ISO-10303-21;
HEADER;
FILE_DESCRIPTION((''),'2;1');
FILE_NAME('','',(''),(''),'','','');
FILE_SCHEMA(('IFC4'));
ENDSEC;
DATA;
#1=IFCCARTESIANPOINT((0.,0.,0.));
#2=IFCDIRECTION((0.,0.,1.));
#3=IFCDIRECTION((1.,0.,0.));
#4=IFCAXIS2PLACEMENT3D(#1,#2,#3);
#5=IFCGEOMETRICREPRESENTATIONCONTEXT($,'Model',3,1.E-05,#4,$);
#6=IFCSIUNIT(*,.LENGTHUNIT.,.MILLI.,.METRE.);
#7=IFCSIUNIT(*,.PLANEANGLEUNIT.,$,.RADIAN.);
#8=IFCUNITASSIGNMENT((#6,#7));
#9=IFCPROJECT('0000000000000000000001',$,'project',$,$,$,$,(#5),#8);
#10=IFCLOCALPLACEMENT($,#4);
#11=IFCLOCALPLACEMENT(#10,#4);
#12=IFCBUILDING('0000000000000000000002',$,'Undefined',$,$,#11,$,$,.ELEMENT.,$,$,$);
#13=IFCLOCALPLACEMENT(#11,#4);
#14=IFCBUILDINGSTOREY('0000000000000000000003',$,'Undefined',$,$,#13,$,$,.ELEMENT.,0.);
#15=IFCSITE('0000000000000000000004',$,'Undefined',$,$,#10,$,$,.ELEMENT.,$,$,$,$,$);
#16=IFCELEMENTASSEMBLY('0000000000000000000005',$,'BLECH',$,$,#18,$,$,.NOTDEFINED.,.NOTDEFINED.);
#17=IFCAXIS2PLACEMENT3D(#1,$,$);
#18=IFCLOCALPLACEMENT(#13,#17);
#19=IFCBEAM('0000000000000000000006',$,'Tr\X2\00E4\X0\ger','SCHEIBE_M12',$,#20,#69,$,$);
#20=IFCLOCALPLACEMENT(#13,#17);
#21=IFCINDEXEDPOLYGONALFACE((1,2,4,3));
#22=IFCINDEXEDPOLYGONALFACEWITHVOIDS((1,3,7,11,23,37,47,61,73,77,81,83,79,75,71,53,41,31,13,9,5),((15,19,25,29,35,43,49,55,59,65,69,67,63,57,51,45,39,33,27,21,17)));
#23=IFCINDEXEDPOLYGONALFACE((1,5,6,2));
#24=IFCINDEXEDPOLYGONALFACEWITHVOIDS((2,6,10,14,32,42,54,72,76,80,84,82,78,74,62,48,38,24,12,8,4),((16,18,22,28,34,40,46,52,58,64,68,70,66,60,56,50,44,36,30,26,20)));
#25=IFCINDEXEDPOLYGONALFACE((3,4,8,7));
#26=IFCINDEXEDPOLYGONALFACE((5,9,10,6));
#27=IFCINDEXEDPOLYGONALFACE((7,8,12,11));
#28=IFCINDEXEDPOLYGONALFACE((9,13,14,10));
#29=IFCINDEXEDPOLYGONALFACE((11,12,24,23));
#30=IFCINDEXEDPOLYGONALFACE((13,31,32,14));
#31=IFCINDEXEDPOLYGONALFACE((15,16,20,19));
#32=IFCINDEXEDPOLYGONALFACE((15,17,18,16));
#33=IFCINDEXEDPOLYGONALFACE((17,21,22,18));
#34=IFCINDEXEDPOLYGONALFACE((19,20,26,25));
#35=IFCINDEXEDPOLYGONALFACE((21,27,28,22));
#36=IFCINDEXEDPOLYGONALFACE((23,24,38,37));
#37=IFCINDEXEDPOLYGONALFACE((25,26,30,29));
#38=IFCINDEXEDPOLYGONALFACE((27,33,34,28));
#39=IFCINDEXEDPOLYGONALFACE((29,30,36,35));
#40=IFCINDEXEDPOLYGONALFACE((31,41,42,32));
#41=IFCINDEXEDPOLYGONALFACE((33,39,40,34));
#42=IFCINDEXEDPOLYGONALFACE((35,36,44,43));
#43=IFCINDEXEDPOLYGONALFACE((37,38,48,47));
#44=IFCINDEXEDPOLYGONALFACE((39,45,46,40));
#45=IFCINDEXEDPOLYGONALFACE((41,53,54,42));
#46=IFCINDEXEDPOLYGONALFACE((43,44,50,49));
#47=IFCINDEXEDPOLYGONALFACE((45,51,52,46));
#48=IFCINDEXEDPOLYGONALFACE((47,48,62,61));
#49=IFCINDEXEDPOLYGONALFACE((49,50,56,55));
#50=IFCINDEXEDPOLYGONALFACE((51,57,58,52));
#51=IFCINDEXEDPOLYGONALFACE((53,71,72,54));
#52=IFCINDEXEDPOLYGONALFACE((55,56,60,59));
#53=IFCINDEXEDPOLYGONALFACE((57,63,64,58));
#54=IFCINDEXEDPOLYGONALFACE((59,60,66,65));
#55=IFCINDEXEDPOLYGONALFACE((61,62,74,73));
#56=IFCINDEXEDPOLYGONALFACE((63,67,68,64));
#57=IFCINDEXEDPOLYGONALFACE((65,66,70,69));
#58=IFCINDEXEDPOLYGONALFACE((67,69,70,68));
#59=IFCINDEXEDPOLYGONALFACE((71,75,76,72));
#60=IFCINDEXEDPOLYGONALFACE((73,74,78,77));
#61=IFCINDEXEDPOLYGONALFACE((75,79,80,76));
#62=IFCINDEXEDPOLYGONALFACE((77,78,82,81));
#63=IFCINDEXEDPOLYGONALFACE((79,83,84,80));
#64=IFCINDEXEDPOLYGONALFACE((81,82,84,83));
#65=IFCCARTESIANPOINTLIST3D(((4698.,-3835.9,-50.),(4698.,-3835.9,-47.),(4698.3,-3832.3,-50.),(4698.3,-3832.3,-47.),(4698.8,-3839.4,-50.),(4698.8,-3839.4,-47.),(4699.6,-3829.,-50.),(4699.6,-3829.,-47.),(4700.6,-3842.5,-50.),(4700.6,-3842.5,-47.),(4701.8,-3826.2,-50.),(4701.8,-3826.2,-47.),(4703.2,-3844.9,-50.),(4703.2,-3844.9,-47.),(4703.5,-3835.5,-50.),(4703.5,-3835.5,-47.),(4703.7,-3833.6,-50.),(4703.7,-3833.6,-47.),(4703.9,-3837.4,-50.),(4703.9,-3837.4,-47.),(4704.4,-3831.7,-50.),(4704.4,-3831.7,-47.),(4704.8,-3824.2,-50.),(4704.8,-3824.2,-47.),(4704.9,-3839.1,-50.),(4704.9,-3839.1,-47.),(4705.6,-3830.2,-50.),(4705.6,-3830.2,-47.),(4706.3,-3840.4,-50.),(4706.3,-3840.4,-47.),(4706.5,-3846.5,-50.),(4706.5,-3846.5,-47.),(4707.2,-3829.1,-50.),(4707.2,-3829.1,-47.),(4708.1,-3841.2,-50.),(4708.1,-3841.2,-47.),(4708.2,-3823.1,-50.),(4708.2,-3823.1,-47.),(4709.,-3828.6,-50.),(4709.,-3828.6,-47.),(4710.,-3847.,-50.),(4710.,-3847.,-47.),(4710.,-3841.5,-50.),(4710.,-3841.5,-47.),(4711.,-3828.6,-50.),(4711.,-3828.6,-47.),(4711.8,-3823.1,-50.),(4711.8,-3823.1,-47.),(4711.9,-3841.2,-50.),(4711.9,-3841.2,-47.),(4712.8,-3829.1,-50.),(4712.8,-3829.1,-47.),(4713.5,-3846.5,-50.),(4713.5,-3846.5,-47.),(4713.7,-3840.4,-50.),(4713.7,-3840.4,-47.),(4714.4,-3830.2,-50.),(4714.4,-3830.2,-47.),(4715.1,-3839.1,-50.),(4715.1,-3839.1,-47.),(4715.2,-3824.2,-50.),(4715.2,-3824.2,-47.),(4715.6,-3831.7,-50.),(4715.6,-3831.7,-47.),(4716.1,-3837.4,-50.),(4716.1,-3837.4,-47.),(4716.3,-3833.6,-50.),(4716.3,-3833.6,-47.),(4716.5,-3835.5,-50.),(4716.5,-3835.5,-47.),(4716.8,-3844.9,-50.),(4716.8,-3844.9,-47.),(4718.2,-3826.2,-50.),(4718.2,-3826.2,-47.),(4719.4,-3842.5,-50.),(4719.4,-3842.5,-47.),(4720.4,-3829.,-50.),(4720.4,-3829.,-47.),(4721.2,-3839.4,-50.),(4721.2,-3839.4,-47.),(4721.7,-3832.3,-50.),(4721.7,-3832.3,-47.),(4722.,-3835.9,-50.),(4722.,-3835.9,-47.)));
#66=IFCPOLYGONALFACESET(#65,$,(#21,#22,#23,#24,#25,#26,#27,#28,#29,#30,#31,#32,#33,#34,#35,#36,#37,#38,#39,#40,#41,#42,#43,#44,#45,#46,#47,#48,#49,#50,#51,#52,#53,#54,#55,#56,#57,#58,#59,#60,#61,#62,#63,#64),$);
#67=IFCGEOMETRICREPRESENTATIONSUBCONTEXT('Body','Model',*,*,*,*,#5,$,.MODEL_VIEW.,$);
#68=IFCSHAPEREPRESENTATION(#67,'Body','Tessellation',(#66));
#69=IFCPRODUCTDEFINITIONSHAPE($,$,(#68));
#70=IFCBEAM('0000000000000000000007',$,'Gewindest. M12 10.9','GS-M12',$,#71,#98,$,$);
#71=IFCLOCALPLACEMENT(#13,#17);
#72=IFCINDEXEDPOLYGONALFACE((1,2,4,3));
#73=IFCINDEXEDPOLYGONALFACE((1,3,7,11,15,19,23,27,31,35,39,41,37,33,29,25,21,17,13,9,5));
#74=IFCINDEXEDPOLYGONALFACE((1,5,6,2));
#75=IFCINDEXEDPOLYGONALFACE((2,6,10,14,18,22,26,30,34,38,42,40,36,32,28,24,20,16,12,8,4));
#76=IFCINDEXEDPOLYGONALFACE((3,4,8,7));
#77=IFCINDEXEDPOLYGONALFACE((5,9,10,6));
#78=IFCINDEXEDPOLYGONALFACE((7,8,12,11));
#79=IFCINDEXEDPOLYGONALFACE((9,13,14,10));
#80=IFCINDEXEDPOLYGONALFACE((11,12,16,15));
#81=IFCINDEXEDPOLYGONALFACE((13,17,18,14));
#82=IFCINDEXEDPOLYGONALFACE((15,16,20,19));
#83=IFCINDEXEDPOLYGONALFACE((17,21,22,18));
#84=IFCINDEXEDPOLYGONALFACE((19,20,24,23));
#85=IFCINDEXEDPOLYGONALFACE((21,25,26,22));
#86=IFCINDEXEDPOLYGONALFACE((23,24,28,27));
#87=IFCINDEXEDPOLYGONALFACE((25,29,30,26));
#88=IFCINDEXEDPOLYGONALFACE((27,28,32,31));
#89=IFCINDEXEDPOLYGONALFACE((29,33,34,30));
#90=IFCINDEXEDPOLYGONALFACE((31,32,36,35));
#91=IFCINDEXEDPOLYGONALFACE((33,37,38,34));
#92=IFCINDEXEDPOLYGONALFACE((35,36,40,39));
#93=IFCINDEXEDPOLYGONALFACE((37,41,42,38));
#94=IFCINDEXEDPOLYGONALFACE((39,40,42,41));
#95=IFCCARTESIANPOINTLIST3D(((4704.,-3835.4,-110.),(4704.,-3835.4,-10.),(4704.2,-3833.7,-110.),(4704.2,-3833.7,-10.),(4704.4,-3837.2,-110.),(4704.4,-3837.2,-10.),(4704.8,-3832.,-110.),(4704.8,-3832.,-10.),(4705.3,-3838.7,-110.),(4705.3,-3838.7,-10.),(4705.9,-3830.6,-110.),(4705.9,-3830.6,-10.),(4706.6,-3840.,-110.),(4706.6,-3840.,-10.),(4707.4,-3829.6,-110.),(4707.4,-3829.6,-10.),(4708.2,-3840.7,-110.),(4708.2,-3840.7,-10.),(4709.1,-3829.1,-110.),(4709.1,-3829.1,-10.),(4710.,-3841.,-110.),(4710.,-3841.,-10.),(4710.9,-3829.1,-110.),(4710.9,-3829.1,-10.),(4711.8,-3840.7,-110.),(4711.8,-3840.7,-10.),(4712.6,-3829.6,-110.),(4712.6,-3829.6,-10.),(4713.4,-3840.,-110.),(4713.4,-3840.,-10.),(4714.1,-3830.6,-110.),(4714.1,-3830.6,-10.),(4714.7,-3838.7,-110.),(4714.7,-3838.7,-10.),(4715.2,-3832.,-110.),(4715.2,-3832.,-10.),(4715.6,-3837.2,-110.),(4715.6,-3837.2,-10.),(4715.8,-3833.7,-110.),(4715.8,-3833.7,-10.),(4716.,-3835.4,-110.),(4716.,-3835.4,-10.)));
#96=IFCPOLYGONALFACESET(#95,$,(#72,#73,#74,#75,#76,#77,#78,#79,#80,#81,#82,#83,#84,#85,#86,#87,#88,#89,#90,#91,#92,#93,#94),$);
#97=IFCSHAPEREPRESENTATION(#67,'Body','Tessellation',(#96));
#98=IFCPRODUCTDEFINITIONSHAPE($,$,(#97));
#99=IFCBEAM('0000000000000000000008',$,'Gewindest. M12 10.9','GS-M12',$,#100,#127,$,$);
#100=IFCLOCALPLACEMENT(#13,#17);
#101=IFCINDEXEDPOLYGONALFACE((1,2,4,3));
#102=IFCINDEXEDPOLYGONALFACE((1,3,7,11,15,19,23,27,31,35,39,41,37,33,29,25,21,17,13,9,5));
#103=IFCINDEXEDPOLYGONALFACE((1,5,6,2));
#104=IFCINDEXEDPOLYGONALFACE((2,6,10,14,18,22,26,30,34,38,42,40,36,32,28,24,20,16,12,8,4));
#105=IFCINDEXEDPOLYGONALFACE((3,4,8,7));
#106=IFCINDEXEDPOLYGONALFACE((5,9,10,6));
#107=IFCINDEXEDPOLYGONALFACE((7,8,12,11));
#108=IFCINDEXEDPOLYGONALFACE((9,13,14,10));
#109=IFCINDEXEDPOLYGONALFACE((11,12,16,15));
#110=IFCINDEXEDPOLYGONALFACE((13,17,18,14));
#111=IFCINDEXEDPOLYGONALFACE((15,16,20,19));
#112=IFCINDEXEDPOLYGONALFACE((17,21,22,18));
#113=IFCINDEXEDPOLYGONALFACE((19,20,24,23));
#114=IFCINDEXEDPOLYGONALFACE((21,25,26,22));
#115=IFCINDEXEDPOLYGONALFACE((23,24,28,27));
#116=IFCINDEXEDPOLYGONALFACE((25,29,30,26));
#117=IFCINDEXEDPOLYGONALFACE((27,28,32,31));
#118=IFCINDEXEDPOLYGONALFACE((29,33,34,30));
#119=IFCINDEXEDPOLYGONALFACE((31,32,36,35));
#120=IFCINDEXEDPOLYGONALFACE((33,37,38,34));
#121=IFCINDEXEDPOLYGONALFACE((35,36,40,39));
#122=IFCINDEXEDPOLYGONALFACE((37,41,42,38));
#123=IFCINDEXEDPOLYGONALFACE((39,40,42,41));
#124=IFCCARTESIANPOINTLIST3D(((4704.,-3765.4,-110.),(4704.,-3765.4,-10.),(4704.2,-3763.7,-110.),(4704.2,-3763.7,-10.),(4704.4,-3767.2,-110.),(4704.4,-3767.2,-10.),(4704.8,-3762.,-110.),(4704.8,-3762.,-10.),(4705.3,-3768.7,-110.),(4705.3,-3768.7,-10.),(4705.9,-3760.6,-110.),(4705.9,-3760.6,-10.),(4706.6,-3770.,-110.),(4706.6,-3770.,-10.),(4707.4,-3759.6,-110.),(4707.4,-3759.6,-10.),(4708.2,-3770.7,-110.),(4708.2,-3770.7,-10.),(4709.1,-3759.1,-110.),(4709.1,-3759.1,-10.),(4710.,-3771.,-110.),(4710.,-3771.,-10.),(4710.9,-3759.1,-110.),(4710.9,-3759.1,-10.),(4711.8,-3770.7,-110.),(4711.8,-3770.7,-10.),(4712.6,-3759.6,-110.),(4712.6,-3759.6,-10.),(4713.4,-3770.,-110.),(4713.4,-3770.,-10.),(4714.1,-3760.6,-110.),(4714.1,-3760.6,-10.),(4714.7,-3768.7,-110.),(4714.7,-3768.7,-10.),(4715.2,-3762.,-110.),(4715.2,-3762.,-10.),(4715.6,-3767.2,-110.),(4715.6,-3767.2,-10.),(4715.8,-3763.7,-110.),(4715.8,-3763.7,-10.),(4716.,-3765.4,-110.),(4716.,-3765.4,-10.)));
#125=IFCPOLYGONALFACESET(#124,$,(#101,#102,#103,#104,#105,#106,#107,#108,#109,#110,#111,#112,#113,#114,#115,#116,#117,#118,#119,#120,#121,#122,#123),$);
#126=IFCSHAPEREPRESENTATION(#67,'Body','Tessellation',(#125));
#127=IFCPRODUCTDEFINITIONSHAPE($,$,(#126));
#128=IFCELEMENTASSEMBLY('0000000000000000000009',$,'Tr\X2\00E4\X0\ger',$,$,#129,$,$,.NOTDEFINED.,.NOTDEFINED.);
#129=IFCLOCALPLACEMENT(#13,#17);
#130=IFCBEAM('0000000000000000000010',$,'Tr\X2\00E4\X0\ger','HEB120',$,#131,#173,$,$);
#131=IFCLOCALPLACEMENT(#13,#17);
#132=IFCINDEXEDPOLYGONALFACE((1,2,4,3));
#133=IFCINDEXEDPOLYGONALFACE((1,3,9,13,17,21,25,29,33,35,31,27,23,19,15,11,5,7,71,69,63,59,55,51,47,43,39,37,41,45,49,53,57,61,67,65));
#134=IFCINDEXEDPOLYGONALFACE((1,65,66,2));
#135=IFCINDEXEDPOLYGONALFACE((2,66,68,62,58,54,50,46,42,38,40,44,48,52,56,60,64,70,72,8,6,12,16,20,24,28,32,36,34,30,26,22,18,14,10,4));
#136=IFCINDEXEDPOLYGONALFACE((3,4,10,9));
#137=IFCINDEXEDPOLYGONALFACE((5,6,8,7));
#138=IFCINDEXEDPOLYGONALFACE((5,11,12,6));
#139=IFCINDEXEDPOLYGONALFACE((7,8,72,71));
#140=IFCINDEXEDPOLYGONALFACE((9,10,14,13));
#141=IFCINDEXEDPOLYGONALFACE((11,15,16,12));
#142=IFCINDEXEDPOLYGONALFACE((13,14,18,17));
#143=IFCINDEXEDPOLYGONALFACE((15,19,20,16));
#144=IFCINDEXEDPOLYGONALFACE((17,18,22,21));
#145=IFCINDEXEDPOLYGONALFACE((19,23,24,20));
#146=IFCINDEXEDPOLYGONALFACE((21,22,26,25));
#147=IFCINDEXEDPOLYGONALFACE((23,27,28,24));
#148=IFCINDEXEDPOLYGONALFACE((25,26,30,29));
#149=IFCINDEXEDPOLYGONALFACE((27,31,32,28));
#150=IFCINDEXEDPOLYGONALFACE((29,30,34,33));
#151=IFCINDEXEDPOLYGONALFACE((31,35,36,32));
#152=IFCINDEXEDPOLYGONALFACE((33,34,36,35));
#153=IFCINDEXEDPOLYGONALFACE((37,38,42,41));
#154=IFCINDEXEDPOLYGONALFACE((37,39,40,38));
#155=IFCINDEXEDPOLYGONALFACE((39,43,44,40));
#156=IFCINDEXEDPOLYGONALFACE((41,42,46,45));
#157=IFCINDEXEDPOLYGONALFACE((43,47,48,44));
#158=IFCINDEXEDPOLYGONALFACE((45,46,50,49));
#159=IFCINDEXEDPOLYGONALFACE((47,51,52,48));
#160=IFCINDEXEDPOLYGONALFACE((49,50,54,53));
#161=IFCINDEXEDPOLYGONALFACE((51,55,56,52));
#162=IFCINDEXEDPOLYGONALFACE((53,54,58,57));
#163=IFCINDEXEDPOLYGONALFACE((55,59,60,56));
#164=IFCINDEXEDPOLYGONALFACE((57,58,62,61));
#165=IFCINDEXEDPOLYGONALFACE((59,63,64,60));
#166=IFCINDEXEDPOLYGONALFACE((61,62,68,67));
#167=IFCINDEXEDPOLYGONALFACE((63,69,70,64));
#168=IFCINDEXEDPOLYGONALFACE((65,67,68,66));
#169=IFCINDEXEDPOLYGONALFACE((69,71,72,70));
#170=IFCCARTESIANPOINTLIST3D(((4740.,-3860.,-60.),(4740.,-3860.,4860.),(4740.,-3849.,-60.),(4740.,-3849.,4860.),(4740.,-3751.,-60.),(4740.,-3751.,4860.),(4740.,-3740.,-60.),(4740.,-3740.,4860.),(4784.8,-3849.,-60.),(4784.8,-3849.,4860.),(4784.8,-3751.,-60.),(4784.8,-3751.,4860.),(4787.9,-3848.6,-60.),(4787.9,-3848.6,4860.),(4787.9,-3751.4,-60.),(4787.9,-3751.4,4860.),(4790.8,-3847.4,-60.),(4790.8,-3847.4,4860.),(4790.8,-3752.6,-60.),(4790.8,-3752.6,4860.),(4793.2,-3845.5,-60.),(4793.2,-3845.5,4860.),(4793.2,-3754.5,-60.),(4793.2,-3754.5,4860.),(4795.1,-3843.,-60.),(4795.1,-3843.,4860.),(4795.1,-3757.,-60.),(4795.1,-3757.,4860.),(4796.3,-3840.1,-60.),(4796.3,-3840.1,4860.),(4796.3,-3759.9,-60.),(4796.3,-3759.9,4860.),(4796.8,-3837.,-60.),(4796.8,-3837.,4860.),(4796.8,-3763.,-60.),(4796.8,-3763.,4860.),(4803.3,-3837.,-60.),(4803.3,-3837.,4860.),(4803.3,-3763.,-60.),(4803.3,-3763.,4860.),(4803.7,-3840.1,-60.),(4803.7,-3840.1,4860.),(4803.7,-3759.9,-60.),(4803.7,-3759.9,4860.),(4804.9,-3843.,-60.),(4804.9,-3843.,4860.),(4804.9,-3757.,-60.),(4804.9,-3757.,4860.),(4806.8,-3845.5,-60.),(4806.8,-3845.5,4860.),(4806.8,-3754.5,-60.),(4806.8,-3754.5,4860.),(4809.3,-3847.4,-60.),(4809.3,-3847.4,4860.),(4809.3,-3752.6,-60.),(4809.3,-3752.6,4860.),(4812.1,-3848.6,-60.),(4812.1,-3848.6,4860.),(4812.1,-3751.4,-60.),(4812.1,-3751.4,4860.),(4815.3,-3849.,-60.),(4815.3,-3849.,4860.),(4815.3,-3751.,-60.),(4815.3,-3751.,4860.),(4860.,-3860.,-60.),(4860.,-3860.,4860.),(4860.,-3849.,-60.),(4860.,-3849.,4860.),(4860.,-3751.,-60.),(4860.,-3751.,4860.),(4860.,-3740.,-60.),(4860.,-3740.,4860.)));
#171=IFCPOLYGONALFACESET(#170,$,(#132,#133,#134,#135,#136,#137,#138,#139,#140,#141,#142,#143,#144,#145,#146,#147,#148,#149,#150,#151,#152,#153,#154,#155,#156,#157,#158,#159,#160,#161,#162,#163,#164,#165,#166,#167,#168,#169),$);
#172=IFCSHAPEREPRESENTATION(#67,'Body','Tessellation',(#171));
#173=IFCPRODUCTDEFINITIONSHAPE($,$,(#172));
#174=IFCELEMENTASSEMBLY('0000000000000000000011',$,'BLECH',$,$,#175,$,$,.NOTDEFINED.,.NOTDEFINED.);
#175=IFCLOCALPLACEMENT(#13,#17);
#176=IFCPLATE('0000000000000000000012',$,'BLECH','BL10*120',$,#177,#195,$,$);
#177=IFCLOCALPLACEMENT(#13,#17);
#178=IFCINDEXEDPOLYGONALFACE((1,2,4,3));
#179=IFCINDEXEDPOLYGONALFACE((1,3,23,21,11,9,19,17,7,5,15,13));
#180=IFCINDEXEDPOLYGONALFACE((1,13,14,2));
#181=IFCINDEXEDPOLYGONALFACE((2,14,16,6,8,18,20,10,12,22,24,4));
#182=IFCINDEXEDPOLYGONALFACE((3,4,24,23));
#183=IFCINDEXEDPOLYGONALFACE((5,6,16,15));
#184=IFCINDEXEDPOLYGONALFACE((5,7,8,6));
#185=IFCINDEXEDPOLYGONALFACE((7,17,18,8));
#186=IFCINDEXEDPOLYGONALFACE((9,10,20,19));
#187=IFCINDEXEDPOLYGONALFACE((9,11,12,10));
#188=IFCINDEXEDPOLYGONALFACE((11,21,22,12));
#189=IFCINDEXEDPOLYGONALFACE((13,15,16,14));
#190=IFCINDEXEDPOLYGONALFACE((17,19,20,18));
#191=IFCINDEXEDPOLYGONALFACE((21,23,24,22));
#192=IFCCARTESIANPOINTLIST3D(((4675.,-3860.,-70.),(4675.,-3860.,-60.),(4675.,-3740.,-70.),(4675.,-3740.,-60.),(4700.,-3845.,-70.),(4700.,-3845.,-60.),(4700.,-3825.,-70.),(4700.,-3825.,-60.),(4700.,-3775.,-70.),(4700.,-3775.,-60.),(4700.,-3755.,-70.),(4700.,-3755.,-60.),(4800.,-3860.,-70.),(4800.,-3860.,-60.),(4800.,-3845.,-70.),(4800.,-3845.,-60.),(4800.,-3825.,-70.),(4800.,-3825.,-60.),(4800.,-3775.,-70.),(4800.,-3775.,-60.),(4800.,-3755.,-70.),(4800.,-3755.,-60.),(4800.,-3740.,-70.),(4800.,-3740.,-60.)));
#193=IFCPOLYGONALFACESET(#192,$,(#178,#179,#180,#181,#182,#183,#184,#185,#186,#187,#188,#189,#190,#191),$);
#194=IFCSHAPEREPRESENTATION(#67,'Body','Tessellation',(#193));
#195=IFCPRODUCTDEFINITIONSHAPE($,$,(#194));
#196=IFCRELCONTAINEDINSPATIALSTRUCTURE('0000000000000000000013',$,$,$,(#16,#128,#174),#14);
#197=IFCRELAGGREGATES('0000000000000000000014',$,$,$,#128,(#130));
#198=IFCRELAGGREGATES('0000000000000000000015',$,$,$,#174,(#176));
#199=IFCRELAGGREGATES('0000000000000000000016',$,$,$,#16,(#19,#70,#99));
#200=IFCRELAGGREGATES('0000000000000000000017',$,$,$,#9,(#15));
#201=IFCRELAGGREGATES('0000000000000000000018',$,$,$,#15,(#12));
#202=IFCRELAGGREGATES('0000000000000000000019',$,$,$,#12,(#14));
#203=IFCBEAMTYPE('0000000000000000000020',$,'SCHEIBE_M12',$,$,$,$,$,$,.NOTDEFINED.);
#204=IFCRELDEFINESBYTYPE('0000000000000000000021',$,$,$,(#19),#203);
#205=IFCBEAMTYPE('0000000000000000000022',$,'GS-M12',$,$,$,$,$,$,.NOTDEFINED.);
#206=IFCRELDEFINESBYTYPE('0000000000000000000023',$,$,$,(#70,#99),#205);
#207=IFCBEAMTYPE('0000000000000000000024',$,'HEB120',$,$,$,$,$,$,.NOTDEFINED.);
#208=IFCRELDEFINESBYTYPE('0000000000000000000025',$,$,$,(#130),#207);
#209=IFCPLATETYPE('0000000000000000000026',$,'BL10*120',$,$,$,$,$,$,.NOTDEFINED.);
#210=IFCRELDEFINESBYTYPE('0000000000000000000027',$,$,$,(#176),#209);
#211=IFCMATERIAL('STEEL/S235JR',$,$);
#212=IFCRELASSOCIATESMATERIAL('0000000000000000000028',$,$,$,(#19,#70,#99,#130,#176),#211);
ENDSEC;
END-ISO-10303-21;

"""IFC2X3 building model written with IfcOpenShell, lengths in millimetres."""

from ifc_helpers import new_model, si_unit, frame, origin_with_axes, origin_2d_with_axis, place, context, subcontext, project, spatial, polyline, circle, hollow_circle, i_section, outline, extrude, material, type_object, element, aggregate, save


model = new_model("IFC2X3")

# Units and contexts
model_context = context("Model", 3, precision=1e-05, world=origin_with_axes())
body_context = subcontext(model_context, "Body", "Model", "MODEL_VIEW")
ifc_project = project(units=[si_unit("LENGTHUNIT", "METRE", prefix="MILLI"), si_unit("PLANEANGLEUNIT", "RADIAN")], contexts=[model_context])

# Site, building, storey
site_placement = place(None, origin_with_axes())
site = spatial("IfcSite", under=ifc_project, at=site_placement, Name="Undefined", CompositionType="ELEMENT")
building_placement = place(site_placement, origin_with_axes())
building = spatial("IfcBuilding", under=site, at=building_placement, Name="Undefined", CompositionType="ELEMENT")
storey_placement = place(building_placement, origin_with_axes())
storey = spatial("IfcBuildingStorey", under=building, at=storey_placement, Name="Undefined", CompositionType="ELEMENT", Elevation=0.0)

# Shared definitions
ifc_material_1 = material(Name="STEEL/S235JR")

# Element assembly, beams
assembly_1_placement = place(storey_placement, origin_with_axes())
assembly_1 = element("IfcElementAssembly", 1, at=assembly_1_placement, inside=storey, Name="BLECH", AssemblyPlace="NOTDEFINED", PredefinedType="NOTDEFINED")
beam_type_1 = type_object("IfcBeamType", Name="SCHEIBE_M12", PredefinedType="NOTDEFINED")
beam_1_placement = place(assembly_1_placement, frame((4710.0, -3835.0, -47.0), z_axis=(1.0, 0.0, 0.0), x_axis=(0.0, 0.0, -1.0)))
beam_1 = element("IfcBeam", 2, at=beam_1_placement, type_object=beam_type_1, material=ifc_material_1, Name="Träger", Description="SCHEIBE_M12", context=body_context, shape_type="SweptSolid", body=[
    extrude(hollow_circle(Radius=12.0, WallThickness=5.5, at=origin_2d_with_axis()), frame((3.0, 0.0, 0.0), z_axis=(-1.0, 0.0, 0.0), x_axis=(0.0, -1.0, 0.0)), (0.0, 0.0, 1.0), 3.0),
])
beam_type_2 = type_object("IfcBeamType", Name="GS-M12", PredefinedType="NOTDEFINED")
beam_2_placement = place(assembly_1_placement, frame((4710.0, -3835.0, -10.0), z_axis=(1.0, 0.0, 0.0), x_axis=(0.0, 0.0, -1.0)))
beam_2 = element("IfcBeam", 3, at=beam_2_placement, type_object=beam_type_2, material=ifc_material_1, Name="Gewindest. M12 10.9", Description="GS-M12", context=body_context, shape_type="SweptSolid", body=[
    extrude(circle(Radius=6.0, at=origin_2d_with_axis()), frame((100.0, 0.0, 0.0), z_axis=(-1.0, 0.0, 0.0), x_axis=(0.0, -1.0, 0.0)), (0.0, 0.0, 1.0), 100.0),
])
beam_3_placement = place(assembly_1_placement, frame((4710.0, -3765.0, -10.0), z_axis=(1.0, 0.0, 0.0), x_axis=(0.0, 0.0, -1.0)))
beam_3 = element("IfcBeam", 4, at=beam_3_placement, type_object=beam_type_2, material=ifc_material_1, Name="Gewindest. M12 10.9", Description="GS-M12", context=body_context, shape_type="SweptSolid", body=[
    extrude(circle(Radius=6.0, at=origin_2d_with_axis()), frame((100.0, 0.0, 0.0), z_axis=(-1.0, 0.0, 0.0), x_axis=(0.0, -1.0, 0.0)), (0.0, 0.0, 1.0), 100.0),
])

# Element assembly, beam
assembly_2_placement = place(storey_placement, origin_with_axes())
assembly_2 = element("IfcElementAssembly", 5, at=assembly_2_placement, inside=storey, Name="Träger", AssemblyPlace="NOTDEFINED", PredefinedType="NOTDEFINED")
beam_type_3 = type_object("IfcBeamType", Name="HEB120", PredefinedType="NOTDEFINED")
beam_4_placement = place(assembly_2_placement, frame((4800.0, -3800.0, -60.0), z_axis=(0.0, 1.0, 0.0), x_axis=(0.0, 0.0, 1.0)))
beam_4 = element("IfcBeam", 6, at=beam_4_placement, type_object=beam_type_3, material=ifc_material_1, Name="Träger", Description="HEB120", context=body_context, shape_type="SweptSolid", body=[
    extrude(i_section(OverallWidth=120.0, OverallDepth=120.0, WebThickness=6.5, FlangeThickness=11.0, FilletRadius=12.0, at=origin_2d_with_axis()), frame((4920.0, 0.0, 0.0), z_axis=(-1.0, 0.0, 0.0), x_axis=(0.0, -1.0, 0.0)), (0.0, 0.0, 1.0), 4920.0),
])
aggregate(assembly_2, [beam_4])

# Element assembly, plate
assembly_3_placement = place(storey_placement, origin_with_axes())
assembly_3 = element("IfcElementAssembly", 7, at=assembly_3_placement, inside=storey, Name="BLECH", AssemblyPlace="NOTDEFINED", PredefinedType="NOTDEFINED")
plate_type_1 = type_object("IfcPlateType", Name="BL10*120", PredefinedType="NOTDEFINED")
plate_1_placement = place(assembly_3_placement, frame((4675.0, -3740.0, -65.0), z_axis=(0.0, 0.0, -1.0), x_axis=(1.0, 0.0, 0.0)))
plate_1 = element("IfcPlate", 8, at=plate_1_placement, type_object=plate_type_1, material=ifc_material_1, Name="BLECH", Description="BL10*120", context=body_context, shape_type="SweptSolid", body=[
    extrude(outline(polyline([(0.0, 0.0), (125.0, 0.0), (125.0, 15.0), (25.0, 15.0), (25.0, 35.0), (125.0, 35.0), (125.0, 85.0), (25.0, 85.0), (25.0, 105.0), (125.0, 105.0), (125.0, 120.0), (0.0, 120.0), (0.0, 0.0)])), frame((0.0, 0.0, -5.0), z_axis=(0.0, 0.0, 1.0), x_axis=(1.0, 0.0, 0.0)), (0.0, 0.0, 1.0), 10.0),
])
aggregate(assembly_3, [plate_1])

aggregate(assembly_1, [beam_1, beam_2, beam_3])

save(model, "model.ifc")
